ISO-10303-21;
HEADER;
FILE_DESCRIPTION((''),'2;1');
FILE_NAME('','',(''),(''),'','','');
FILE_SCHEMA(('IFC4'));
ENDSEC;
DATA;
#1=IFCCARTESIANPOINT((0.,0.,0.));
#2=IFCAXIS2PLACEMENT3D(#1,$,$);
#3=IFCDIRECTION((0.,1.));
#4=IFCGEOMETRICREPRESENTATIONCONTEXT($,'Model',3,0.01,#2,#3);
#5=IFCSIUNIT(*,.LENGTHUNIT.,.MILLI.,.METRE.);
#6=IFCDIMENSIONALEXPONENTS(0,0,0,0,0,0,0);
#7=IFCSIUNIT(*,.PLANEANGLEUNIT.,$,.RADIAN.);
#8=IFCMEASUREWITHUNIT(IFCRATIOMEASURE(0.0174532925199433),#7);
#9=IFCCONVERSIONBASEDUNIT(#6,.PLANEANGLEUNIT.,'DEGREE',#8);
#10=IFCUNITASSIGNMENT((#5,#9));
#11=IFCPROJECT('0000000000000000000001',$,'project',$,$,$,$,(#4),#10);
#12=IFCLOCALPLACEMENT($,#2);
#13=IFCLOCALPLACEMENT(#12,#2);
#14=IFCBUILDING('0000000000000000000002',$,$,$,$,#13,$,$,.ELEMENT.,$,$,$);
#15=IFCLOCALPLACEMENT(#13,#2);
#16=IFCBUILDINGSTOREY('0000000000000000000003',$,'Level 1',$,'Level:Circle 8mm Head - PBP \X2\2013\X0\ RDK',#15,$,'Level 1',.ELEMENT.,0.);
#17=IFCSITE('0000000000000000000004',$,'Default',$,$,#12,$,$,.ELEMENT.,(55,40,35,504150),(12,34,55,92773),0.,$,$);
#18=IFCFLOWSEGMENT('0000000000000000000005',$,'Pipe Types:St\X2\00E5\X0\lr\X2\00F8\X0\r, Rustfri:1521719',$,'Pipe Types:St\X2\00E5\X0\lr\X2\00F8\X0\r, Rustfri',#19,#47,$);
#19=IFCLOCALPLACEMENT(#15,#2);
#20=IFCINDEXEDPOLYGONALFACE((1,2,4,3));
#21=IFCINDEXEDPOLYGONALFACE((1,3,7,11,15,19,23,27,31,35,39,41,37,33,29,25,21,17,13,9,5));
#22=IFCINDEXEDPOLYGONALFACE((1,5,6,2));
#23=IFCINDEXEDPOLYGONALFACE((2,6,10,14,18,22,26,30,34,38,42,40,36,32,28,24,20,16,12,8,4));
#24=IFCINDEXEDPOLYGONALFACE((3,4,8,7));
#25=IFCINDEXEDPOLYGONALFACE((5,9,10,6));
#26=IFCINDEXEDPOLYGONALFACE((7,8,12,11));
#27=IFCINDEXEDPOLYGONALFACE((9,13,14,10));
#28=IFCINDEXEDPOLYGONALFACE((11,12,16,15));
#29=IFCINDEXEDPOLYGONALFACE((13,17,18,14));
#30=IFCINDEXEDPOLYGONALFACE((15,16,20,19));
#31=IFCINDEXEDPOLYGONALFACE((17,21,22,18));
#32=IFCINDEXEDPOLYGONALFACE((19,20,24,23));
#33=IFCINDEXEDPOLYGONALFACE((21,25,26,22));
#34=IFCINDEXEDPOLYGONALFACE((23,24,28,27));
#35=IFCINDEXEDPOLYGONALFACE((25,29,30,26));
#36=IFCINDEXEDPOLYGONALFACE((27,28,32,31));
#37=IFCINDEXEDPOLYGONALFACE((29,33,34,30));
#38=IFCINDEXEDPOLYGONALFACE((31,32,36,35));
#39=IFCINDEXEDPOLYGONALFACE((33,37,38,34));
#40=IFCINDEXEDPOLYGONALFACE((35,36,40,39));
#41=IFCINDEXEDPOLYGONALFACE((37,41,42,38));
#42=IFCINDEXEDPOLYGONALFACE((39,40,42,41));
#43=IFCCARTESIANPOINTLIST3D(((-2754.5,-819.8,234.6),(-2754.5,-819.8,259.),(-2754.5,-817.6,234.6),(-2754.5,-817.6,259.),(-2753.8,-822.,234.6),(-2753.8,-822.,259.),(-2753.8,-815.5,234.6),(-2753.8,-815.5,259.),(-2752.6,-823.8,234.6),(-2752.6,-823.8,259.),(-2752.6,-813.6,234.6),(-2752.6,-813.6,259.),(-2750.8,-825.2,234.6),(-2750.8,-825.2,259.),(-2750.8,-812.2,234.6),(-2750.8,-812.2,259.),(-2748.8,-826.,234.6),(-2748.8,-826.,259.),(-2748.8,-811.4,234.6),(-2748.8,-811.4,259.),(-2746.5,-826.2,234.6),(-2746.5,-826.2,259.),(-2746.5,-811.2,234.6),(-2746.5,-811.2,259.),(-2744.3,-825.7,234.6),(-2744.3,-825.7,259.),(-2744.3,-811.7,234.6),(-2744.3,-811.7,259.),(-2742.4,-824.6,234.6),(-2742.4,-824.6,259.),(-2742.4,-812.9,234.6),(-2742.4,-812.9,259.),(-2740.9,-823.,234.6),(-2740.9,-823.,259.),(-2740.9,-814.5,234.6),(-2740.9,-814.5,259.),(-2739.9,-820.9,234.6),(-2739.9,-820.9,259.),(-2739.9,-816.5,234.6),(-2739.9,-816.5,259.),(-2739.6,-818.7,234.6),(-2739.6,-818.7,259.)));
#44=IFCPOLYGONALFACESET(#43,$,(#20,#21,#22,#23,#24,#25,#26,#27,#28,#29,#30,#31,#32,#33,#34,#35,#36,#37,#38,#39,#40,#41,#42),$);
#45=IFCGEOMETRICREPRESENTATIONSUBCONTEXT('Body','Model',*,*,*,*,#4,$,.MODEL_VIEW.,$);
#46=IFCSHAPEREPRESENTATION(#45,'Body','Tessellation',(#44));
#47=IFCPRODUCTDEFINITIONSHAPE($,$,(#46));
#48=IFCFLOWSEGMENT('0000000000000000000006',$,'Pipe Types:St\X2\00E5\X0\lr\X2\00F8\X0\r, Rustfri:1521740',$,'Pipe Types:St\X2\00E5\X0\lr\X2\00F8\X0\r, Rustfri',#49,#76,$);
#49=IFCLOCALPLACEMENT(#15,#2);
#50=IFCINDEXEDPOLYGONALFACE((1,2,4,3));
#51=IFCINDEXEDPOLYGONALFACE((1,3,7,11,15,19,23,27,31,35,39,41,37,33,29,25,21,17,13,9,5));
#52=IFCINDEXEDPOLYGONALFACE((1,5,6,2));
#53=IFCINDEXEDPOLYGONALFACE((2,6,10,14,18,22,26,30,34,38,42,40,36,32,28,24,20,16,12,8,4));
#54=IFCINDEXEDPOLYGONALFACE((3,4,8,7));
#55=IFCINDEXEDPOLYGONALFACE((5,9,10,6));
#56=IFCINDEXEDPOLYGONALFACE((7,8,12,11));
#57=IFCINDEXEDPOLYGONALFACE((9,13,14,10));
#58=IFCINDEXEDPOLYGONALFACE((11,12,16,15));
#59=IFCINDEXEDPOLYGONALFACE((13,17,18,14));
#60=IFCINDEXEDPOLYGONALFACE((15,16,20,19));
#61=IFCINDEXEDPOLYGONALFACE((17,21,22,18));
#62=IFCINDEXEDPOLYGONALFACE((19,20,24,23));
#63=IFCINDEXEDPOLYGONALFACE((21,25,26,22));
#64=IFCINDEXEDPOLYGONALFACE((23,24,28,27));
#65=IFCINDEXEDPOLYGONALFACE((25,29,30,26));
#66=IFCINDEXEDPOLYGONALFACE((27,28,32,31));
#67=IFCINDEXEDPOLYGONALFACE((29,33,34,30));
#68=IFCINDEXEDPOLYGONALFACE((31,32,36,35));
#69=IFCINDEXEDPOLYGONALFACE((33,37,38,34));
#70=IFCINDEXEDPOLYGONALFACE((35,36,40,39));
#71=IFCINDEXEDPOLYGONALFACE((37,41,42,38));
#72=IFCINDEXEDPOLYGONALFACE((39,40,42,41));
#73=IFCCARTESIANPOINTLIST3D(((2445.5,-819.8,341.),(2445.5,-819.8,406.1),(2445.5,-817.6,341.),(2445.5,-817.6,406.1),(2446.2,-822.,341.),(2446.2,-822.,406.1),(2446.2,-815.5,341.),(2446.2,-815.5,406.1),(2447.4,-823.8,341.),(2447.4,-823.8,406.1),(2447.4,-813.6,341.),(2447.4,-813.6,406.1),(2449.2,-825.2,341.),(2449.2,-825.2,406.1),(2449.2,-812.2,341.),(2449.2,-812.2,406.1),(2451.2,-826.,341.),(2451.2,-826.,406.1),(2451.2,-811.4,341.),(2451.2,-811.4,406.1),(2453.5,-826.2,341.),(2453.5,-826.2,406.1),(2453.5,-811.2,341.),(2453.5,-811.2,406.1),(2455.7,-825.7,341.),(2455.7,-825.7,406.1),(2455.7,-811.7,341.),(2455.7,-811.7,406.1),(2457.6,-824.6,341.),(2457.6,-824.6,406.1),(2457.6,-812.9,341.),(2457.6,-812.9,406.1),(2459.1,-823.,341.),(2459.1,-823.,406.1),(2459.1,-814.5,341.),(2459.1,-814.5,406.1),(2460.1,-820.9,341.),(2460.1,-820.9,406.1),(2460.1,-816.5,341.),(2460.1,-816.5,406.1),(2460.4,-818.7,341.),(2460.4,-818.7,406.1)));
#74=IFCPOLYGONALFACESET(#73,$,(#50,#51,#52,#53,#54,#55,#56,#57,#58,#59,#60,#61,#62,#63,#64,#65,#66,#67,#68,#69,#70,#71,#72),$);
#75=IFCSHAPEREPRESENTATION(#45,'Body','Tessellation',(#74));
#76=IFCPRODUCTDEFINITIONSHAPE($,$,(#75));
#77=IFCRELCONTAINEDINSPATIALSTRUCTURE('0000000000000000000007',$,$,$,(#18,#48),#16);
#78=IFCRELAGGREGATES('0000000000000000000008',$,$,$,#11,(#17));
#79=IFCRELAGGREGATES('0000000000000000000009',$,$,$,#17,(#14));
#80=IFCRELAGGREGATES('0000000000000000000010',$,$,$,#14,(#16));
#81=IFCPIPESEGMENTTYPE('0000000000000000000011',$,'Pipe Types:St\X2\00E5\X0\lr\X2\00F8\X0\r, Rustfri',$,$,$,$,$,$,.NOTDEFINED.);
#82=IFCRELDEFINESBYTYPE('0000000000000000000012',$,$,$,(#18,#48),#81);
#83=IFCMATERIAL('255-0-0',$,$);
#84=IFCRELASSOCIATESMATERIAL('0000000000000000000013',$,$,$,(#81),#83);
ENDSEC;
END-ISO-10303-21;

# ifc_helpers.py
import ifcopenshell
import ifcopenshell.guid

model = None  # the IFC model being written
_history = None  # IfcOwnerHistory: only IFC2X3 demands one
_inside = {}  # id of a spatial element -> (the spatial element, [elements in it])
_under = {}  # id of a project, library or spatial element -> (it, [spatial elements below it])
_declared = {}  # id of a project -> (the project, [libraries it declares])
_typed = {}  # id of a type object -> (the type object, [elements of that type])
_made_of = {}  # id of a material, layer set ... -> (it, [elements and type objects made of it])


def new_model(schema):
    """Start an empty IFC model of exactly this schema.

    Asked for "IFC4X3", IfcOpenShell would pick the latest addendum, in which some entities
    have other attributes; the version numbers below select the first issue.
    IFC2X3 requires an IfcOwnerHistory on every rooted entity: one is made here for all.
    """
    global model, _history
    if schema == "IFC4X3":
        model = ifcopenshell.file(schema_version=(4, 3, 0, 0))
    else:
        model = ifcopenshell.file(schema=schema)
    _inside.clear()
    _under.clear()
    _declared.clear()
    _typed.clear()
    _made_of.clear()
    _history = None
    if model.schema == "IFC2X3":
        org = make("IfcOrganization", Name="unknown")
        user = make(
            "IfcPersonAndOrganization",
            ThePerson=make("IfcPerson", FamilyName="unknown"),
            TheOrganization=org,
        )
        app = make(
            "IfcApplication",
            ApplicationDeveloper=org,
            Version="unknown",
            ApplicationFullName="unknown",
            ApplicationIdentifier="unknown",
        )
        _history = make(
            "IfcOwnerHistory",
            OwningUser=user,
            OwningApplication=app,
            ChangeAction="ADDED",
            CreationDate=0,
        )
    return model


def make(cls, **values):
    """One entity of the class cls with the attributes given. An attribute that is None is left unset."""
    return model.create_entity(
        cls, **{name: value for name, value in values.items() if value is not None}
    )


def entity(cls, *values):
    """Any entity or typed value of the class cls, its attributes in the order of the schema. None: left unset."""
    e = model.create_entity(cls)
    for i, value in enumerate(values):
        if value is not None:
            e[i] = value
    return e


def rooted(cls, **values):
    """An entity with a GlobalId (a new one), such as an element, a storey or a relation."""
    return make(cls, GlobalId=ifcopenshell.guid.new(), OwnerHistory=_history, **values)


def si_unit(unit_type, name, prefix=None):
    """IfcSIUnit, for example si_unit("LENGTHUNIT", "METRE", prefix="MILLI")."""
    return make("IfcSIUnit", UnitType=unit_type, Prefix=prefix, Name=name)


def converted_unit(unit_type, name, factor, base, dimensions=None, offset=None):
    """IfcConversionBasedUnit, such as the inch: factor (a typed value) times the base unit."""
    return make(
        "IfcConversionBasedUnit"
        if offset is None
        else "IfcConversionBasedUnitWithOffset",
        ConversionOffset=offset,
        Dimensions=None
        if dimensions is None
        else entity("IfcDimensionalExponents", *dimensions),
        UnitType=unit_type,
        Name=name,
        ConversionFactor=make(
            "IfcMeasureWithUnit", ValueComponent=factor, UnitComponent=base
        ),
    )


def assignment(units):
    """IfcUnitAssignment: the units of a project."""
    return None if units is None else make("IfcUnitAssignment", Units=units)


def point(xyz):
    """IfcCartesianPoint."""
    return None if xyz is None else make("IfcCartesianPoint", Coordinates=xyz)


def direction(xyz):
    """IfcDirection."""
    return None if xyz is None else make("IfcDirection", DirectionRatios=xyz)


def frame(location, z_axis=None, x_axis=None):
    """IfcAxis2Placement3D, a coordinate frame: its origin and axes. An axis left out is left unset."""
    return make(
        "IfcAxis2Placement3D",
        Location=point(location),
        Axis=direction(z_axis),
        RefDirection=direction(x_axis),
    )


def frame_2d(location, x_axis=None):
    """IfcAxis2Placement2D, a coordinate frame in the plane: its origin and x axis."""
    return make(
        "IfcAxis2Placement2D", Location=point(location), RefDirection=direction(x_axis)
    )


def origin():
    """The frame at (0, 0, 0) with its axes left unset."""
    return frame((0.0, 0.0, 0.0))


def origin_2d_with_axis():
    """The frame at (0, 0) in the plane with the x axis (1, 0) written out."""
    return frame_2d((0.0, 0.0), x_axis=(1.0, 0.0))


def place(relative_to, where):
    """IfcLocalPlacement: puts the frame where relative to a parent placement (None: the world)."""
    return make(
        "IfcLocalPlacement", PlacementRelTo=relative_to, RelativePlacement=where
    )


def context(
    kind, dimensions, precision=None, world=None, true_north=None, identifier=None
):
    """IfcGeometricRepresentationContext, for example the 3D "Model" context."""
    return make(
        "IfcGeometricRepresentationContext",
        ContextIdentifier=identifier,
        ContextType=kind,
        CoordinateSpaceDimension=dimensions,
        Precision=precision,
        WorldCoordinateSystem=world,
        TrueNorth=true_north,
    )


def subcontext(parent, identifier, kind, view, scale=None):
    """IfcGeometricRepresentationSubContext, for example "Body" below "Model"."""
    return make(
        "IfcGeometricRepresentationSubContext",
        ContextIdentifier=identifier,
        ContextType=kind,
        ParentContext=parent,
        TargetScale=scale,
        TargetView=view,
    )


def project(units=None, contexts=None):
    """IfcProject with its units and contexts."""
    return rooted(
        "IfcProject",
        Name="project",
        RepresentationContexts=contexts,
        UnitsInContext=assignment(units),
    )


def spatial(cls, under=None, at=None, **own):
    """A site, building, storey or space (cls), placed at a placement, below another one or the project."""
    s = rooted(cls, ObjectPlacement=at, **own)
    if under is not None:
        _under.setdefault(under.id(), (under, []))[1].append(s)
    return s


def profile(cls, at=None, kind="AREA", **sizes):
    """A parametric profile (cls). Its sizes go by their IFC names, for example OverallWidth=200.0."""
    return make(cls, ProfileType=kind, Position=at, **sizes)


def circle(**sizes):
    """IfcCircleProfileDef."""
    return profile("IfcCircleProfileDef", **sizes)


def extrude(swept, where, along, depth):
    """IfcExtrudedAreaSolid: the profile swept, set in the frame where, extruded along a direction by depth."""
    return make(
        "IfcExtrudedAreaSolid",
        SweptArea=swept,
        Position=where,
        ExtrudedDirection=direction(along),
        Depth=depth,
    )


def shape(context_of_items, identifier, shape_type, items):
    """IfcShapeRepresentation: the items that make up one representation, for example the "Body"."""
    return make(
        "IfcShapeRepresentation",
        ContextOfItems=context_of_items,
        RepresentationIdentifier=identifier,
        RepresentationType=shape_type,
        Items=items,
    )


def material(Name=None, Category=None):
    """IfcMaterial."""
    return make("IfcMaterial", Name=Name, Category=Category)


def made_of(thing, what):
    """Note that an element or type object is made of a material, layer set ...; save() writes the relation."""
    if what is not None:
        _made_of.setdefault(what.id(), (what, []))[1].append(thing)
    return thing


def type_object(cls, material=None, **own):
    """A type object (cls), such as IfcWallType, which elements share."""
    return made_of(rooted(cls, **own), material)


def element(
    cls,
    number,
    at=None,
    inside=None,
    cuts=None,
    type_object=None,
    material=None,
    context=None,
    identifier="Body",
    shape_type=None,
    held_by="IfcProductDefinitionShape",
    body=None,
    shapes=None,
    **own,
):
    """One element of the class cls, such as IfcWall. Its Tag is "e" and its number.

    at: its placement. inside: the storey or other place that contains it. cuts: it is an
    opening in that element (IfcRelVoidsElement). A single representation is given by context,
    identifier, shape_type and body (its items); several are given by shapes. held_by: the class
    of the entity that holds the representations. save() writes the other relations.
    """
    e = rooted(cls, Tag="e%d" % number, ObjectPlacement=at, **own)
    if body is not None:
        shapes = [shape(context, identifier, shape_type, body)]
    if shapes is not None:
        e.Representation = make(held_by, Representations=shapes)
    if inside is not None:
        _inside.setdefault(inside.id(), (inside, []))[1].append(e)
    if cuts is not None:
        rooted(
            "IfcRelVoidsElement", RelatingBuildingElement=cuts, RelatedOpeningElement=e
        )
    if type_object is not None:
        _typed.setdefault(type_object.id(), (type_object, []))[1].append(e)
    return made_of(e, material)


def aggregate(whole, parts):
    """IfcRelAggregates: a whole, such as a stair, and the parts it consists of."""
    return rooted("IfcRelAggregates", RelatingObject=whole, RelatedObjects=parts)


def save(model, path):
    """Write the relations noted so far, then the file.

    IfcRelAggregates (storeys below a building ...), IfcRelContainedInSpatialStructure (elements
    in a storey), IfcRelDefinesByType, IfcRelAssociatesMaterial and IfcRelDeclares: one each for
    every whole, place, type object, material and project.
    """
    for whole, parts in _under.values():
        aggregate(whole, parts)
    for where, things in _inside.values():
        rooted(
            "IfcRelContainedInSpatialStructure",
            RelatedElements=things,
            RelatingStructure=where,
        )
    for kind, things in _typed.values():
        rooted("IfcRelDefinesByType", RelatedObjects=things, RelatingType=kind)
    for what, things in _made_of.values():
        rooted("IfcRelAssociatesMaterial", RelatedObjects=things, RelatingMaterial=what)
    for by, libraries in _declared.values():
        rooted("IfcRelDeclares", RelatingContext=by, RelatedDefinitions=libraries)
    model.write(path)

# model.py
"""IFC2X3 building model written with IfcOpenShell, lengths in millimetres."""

from ifc_helpers import new_model, entity, si_unit, converted_unit, direction, frame, frame_2d, origin, origin_2d_with_axis, place, context, subcontext, project, spatial, circle, extrude, material, type_object, element, save


model = new_model("IFC2X3")

# Units and contexts
model_context = context("Model", 3, precision=0.01, world=origin(), true_north=direction((0.0, 1.0)))
body_context = subcontext(model_context, "Body", "Model", "MODEL_VIEW")
ifc_project = project(units=[si_unit("LENGTHUNIT", "METRE", prefix="MILLI"), converted_unit("PLANEANGLEUNIT", "DEGREE", entity("IfcRatioMeasure", 0.0174532925199433), si_unit("PLANEANGLEUNIT", "RADIAN"), dimensions=[0, 0, 0, 0, 0, 0, 0])], contexts=[model_context])

# Site, building, storey
site_placement = place(None, origin())
site = spatial("IfcSite", under=ifc_project, at=site_placement, Name="Default", CompositionType="ELEMENT", RefLatitude=(55, 40, 35, 504150), RefLongitude=(12, 34, 55, 92773), RefElevation=0.0)
building_placement = place(site_placement, origin())
building = spatial("IfcBuilding", under=site, at=building_placement, CompositionType="ELEMENT")
storey_placement = place(building_placement, origin())
storey = spatial("IfcBuildingStorey", under=building, at=storey_placement, Name="Level 1", ObjectType="Level:Circle 8mm Head - PBP – RDK", LongName="Level 1", CompositionType="ELEMENT", Elevation=0.0)

# Flow segments
ifc_material = material(Name="255-0-0")
pipe_segment_type = type_object("IfcPipeSegmentType", Name="Pipe Types:Stålrør, Rustfri", PredefinedType="NOTDEFINED", material=ifc_material)
flow_segment_1_placement = place(storey_placement, origin())
element("IfcFlowSegment", 1, at=flow_segment_1_placement, inside=storey, type_object=pipe_segment_type, Name="Pipe Types:Stålrør, Rustfri:1521719", ObjectType="Pipe Types:Stålrør, Rustfri", context=body_context, shape_type="SweptSolid", body=[
    extrude(circle(Radius=7.5, at=origin_2d_with_axis()), frame((-2747.1, -818.7, 234.6)), (0.0, 0.0, 1.0), 24.4),
])
flow_segment_2_placement = place(storey_placement, origin())
element("IfcFlowSegment", 2, at=flow_segment_2_placement, inside=storey, type_object=pipe_segment_type, Name="Pipe Types:Stålrør, Rustfri:1521740", ObjectType="Pipe Types:Stålrør, Rustfri", context=body_context, shape_type="SweptSolid", body=[
    extrude(circle(Radius=7.5, at=frame_2d((0.0, 0.0), x_axis=(1.0, 0.0))), frame((2452.9, -818.7, 341.0)), (0.0, 0.0, 1.0), 65.1),
])

save(model, "model.ifc")
